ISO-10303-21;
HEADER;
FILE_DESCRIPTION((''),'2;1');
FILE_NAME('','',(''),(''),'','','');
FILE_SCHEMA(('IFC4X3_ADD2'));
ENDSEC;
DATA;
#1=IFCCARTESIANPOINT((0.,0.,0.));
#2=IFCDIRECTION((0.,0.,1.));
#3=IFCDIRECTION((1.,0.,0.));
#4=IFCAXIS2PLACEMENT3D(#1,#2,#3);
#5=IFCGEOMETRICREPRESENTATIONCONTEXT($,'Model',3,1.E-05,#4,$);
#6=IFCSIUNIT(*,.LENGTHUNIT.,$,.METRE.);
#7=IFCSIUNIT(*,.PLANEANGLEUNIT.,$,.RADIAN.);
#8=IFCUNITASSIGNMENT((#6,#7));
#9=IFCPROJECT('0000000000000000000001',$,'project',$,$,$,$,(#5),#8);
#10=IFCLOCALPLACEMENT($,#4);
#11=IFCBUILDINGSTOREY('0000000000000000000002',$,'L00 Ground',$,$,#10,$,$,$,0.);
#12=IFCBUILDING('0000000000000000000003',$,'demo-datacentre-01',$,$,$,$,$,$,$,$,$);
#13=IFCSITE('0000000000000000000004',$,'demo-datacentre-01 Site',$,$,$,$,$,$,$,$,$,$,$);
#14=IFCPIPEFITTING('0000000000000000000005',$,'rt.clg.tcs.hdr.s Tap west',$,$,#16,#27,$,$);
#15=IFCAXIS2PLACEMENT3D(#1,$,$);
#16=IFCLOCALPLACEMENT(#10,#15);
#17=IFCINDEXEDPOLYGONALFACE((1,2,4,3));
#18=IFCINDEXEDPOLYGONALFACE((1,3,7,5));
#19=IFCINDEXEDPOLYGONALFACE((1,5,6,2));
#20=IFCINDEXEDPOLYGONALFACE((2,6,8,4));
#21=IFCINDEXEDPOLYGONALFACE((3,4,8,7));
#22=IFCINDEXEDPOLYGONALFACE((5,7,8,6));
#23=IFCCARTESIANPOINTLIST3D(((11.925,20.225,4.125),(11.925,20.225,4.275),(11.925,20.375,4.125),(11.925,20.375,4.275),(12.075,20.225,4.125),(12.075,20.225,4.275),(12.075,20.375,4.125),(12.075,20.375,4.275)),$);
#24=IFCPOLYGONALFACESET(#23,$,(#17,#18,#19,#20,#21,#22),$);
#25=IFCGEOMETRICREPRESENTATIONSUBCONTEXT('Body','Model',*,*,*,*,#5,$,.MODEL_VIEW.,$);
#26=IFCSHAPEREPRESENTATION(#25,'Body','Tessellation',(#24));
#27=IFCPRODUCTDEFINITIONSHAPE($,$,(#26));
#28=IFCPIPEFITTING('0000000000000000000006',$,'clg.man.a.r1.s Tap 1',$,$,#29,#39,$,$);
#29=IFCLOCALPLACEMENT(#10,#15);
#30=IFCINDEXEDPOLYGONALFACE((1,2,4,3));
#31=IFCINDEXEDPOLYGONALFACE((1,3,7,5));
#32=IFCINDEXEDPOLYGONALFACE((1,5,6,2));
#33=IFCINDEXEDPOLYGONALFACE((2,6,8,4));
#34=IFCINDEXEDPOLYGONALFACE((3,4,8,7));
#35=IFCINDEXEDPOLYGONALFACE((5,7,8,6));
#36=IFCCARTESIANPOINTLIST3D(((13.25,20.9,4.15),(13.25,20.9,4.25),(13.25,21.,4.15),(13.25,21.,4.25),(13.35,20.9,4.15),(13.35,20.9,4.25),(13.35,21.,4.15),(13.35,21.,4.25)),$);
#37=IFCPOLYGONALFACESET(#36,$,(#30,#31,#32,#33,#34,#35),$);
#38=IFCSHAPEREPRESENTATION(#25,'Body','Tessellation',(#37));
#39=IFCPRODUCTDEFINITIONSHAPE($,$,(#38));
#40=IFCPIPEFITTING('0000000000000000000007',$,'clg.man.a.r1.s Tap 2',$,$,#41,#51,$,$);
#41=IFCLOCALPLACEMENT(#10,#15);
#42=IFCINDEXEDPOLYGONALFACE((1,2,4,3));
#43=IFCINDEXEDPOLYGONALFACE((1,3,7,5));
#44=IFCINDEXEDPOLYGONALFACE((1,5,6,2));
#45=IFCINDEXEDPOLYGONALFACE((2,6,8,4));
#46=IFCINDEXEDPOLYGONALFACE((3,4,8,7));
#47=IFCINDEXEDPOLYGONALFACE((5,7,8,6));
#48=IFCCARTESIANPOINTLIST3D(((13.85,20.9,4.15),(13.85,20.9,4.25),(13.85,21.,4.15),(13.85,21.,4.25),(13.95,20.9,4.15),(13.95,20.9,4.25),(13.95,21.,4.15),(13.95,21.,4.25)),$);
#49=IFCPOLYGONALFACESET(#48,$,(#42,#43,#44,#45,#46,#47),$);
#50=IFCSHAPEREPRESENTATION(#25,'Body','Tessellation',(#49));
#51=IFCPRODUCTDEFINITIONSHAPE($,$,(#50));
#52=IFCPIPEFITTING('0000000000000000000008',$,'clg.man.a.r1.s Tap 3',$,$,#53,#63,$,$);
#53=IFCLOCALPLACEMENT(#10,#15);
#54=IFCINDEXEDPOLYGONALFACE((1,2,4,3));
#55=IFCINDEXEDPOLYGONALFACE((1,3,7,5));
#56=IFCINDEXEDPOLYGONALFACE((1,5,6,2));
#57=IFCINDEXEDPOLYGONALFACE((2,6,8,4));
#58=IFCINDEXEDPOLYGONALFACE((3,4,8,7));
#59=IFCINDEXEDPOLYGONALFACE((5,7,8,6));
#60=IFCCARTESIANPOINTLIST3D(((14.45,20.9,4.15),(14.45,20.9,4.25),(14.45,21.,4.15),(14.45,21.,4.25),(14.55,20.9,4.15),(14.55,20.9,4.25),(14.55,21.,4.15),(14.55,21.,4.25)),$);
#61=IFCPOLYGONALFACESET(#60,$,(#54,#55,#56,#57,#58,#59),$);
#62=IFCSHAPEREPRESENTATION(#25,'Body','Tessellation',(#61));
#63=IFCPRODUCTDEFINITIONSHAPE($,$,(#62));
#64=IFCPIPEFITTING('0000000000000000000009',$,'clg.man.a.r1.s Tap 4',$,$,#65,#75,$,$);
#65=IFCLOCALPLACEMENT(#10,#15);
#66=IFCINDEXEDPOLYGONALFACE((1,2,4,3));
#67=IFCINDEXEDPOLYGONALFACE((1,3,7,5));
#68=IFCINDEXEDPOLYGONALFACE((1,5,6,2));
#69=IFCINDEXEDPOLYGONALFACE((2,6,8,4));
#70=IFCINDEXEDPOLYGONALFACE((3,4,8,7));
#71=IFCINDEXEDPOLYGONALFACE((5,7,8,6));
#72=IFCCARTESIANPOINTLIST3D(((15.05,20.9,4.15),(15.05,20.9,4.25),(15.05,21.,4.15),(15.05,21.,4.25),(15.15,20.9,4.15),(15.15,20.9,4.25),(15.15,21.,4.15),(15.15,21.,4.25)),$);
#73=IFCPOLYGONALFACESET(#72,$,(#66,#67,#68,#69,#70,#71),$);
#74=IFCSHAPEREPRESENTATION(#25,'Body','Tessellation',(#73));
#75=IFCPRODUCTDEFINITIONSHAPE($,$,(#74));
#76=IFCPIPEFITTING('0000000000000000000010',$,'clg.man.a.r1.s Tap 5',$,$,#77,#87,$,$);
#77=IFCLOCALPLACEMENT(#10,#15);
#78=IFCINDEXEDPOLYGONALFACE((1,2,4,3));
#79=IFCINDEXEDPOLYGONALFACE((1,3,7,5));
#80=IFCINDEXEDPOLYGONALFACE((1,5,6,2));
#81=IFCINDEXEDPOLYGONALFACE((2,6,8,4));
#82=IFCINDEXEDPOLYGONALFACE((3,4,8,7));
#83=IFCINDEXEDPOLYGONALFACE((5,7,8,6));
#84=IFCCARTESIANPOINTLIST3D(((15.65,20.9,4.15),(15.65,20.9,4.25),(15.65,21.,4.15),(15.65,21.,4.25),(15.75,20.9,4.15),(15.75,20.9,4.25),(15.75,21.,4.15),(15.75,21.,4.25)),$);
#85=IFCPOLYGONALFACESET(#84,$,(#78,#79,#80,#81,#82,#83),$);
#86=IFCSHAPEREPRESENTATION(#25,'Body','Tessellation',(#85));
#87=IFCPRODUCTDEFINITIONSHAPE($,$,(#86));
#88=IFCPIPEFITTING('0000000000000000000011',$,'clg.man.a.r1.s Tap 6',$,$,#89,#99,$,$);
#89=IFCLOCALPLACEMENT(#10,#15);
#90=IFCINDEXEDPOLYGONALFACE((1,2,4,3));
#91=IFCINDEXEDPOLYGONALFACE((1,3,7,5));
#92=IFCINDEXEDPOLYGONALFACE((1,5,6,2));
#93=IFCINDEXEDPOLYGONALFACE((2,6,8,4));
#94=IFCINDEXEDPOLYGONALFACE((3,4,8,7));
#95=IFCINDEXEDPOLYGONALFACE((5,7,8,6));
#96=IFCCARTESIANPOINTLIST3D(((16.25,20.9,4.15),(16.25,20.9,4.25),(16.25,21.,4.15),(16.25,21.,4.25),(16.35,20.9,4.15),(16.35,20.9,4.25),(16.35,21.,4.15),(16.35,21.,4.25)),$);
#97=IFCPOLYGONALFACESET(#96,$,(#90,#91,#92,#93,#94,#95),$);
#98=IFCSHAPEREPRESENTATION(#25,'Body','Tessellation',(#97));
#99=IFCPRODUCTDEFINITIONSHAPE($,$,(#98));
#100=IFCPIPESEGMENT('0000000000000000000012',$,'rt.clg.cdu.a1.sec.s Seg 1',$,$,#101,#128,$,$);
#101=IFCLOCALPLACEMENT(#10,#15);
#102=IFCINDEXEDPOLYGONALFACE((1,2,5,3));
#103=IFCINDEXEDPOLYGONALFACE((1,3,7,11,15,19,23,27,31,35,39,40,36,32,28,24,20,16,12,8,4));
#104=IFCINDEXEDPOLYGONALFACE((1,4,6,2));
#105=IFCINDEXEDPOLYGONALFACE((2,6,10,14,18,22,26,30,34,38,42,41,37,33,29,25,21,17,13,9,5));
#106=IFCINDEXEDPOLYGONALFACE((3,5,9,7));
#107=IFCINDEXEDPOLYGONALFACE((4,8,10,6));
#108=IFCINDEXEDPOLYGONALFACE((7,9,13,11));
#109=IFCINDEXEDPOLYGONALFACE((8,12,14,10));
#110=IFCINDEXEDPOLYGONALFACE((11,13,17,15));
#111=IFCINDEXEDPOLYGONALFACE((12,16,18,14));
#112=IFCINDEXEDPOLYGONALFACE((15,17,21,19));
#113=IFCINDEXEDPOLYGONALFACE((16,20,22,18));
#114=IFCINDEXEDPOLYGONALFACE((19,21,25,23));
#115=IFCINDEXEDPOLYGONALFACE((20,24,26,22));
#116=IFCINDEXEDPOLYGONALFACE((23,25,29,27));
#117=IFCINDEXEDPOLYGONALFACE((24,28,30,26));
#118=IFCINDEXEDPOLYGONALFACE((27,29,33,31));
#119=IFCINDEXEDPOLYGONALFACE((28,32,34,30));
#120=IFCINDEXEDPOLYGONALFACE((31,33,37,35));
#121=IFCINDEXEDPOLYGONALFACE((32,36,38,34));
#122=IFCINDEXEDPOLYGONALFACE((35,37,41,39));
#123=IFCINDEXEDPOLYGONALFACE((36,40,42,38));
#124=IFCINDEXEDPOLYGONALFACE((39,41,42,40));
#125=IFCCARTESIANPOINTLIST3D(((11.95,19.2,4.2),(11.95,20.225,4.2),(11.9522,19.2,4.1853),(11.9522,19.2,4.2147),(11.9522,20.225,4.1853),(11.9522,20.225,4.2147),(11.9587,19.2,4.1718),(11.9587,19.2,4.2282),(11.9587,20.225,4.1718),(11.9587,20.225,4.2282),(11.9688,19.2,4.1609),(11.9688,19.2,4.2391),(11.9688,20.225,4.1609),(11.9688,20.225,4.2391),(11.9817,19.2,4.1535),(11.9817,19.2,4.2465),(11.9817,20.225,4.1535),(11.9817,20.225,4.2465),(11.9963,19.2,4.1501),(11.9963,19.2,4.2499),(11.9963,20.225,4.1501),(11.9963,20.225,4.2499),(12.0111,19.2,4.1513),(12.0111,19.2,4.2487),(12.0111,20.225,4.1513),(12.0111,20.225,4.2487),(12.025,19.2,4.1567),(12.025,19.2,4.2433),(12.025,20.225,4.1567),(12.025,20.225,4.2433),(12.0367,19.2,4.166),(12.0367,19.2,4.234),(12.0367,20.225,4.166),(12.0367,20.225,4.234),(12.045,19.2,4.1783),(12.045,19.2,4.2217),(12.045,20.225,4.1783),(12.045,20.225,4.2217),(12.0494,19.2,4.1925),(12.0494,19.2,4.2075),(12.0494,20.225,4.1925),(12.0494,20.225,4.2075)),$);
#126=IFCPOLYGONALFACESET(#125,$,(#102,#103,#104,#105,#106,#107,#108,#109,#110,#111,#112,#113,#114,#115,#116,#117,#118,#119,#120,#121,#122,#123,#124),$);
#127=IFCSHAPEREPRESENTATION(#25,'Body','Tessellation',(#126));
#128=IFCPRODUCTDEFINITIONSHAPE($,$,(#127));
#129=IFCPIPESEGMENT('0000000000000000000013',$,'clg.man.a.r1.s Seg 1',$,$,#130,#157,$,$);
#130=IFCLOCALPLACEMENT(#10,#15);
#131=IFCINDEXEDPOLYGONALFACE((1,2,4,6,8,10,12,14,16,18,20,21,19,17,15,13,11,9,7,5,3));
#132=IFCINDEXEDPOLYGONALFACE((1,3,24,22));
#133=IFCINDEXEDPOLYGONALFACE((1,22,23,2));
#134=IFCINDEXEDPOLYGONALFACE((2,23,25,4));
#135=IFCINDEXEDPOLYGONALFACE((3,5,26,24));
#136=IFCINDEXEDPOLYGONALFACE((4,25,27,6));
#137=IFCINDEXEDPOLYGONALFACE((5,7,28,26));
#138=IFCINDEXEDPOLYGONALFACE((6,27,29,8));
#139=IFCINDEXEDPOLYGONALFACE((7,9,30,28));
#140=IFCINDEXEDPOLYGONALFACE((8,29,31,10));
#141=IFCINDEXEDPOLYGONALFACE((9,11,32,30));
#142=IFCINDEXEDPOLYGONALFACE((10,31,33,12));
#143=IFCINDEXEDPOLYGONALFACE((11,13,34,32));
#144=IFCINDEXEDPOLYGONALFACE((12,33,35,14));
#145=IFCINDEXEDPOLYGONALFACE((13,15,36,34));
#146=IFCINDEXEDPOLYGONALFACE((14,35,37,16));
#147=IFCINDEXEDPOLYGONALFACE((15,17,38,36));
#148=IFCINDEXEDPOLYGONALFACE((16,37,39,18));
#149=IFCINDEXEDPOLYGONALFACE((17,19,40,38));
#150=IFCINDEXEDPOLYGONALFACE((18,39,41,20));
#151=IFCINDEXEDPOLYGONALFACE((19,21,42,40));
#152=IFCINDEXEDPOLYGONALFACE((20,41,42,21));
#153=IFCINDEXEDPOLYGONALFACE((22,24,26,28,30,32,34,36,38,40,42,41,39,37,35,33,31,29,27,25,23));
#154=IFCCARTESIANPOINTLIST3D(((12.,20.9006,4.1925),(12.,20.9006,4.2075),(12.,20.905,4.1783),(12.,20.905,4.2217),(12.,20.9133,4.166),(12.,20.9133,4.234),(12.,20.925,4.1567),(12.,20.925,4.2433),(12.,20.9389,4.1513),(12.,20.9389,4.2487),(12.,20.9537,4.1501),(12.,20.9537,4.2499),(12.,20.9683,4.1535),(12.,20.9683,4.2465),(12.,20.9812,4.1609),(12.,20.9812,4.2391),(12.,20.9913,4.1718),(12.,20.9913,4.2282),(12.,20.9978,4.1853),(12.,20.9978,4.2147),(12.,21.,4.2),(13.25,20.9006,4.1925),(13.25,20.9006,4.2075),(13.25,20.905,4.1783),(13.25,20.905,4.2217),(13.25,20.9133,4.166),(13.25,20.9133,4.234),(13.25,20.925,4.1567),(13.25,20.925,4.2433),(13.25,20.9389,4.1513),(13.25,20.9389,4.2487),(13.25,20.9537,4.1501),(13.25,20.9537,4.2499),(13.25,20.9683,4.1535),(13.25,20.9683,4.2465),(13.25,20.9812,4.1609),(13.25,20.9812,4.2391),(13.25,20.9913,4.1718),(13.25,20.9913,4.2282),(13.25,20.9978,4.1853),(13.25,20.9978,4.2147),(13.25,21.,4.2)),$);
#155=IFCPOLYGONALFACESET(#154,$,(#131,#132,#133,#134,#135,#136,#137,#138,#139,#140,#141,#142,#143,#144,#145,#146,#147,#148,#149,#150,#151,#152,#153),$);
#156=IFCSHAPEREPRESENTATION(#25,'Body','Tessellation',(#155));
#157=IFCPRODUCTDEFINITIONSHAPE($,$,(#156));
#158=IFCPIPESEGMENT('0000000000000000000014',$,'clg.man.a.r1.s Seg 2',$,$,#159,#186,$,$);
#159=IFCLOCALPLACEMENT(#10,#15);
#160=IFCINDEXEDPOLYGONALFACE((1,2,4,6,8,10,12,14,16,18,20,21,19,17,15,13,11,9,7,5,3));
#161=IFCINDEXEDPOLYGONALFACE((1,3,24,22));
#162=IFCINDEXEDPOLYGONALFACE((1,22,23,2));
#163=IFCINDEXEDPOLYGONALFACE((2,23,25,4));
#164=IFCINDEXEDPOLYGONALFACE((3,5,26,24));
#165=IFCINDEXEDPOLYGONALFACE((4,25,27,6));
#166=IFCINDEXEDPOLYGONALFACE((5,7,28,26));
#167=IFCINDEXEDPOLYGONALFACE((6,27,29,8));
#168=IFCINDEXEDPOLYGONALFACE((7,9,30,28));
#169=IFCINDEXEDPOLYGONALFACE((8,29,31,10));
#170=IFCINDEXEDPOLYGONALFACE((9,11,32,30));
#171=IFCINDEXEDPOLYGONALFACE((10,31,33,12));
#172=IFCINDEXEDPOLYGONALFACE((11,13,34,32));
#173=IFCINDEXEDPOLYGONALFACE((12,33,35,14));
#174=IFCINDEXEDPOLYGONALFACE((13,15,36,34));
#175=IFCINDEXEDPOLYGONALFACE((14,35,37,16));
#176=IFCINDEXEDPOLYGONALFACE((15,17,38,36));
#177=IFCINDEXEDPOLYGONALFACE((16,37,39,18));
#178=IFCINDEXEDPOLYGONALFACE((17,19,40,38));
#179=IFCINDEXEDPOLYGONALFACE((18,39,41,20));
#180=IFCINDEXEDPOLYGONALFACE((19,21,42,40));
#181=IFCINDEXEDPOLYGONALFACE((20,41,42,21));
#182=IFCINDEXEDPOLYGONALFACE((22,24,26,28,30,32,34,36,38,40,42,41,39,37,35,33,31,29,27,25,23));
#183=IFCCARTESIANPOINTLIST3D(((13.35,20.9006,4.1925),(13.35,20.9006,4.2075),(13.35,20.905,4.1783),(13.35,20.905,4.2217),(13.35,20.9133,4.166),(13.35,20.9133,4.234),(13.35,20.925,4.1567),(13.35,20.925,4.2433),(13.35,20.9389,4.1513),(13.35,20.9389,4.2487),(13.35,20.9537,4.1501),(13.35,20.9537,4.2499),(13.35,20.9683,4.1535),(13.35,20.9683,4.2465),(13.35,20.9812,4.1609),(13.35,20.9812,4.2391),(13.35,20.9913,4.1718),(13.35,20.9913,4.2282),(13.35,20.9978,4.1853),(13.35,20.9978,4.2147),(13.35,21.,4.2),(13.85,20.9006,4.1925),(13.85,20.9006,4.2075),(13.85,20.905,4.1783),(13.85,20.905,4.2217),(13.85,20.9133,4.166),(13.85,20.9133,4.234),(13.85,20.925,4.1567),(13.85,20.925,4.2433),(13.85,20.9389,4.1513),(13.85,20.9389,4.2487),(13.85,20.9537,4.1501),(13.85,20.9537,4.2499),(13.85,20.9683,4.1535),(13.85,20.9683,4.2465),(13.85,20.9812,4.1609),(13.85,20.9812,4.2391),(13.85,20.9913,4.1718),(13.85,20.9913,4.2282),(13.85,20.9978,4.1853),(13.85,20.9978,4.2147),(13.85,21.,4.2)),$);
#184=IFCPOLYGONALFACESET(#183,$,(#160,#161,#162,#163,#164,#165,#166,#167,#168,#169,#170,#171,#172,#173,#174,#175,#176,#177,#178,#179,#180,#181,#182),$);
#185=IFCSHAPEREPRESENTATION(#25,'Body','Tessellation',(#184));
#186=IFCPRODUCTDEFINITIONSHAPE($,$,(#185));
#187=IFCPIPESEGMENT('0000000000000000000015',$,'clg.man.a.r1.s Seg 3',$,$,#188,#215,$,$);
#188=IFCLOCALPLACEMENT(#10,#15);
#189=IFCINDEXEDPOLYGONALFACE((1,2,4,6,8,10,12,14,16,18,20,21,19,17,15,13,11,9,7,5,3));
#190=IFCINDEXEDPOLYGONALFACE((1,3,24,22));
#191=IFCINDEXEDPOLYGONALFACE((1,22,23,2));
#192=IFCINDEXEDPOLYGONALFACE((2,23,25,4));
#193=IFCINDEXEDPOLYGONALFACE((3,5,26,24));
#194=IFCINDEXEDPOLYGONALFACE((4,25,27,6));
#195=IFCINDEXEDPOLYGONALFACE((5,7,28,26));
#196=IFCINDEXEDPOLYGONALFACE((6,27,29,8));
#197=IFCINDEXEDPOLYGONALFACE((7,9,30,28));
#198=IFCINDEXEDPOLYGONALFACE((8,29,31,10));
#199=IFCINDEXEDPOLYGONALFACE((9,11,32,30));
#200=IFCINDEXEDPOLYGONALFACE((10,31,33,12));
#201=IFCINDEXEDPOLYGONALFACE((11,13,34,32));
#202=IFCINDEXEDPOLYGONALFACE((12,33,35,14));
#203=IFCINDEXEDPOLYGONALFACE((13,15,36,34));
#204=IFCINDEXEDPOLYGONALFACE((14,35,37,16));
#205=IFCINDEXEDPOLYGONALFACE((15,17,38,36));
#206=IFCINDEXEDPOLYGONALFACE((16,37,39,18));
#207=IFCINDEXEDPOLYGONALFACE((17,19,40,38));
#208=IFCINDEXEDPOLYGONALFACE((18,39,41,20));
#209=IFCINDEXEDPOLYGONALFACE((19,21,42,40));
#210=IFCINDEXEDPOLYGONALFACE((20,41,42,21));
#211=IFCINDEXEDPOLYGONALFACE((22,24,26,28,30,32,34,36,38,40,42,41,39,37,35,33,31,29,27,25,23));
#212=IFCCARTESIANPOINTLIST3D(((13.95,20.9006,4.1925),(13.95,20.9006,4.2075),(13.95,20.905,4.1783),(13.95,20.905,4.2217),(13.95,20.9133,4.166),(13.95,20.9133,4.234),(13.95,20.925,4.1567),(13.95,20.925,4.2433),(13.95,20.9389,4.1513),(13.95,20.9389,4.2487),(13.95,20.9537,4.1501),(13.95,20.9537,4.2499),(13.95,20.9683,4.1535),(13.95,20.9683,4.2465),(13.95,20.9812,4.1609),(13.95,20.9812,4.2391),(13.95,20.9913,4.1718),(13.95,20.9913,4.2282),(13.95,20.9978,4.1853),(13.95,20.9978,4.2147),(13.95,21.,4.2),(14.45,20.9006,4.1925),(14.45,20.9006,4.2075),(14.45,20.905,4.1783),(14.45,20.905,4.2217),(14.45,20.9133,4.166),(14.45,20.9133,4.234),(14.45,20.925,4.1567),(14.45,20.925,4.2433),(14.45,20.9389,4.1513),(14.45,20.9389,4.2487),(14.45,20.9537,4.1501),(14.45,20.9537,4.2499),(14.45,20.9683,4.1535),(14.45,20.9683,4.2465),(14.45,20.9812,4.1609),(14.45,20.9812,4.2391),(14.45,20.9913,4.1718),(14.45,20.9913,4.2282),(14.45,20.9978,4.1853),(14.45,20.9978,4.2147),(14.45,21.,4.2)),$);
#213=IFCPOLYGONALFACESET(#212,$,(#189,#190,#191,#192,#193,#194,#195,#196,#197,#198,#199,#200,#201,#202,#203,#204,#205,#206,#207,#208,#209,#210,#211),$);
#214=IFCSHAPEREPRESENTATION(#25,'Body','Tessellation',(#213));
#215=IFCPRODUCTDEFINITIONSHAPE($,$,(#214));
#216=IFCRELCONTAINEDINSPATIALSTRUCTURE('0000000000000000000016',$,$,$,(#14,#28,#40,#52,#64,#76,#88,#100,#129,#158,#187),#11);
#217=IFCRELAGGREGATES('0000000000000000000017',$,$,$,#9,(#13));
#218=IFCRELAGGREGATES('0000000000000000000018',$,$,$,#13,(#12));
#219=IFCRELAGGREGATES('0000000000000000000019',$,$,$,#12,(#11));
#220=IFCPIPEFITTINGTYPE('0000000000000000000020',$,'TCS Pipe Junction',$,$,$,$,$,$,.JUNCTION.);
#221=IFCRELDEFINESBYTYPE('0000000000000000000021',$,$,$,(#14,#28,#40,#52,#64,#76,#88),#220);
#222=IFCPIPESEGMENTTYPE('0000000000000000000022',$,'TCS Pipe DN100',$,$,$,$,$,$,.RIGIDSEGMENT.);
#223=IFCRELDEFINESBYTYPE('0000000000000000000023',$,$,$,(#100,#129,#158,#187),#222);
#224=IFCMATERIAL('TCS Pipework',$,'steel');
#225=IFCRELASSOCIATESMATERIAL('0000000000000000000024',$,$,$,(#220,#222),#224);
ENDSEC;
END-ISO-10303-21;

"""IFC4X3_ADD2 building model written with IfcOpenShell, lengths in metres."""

from ifc_helpers import new_model, si_unit, frame, origin_with_axes, place, context, subcontext, project, spatial, rectangle, circle, extrude, material, type_object, element, save


model = new_model("IFC4X3_ADD2")

# Units and contexts
model_context = context("Model", 3, precision=1e-05, world=origin_with_axes())
body_context = subcontext(model_context, "Body", "Model", "MODEL_VIEW")
ifc_project = project(units=[si_unit("LENGTHUNIT", "METRE"), si_unit("PLANEANGLEUNIT", "RADIAN")], contexts=[model_context])

# Site, building, storey
site = spatial("IfcSite", under=ifc_project, Name="demo-datacentre-01 Site")
building = spatial("IfcBuilding", under=site, Name="demo-datacentre-01")
storey_placement = place(None, origin_with_axes())
storey = spatial("IfcBuildingStorey", under=building, at=storey_placement, Name="L00 Ground", Elevation=0.0)

# Pipe fittings
ifc_material_1 = material(Name="TCS Pipework", Category="steel")
pipe_fitting_type = type_object("IfcPipeFittingType", Name="TCS Pipe Junction", PredefinedType="JUNCTION", material=ifc_material_1)
pipe_fitting_placement = place(storey_placement, frame((12.0, 20.3, 4.125), z_axis=(0.0, 0.0, 1.0), x_axis=(1.0, 0.0, 0.0)))
element("IfcPipeFitting", 1, at=pipe_fitting_placement, inside=storey, type_object=pipe_fitting_type, Name="rt.clg.tcs.hdr.s Tap west", context=body_context, shape_type="SweptSolid", body=[
    extrude(rectangle(XDim=0.15, YDim=0.15), origin_with_axes(), (0.0, 0.0, 1.0), 0.15),
])
for number, where, z_axis, x_axis, name in (
    (2, (13.3, 20.95, 4.15), (0.0, 0.0, 1.0), (1.0, 0.0, 0.0), "clg.man.a.r1.s Tap 1"),
    (3, (13.9, 20.95, 4.15), (0.0, 0.0, 1.0), (1.0, 0.0, 0.0), "clg.man.a.r1.s Tap 2"),
    (4, (14.5, 20.95, 4.15), (0.0, 0.0, 1.0), (1.0, 0.0, 0.0), "clg.man.a.r1.s Tap 3"),
    (5, (15.1, 20.95, 4.15), (0.0, 0.0, 1.0), (1.0, 0.0, 0.0), "clg.man.a.r1.s Tap 4"),
    (6, (15.7, 20.95, 4.15), (0.0, 0.0, 1.0), (1.0, 0.0, 0.0), "clg.man.a.r1.s Tap 5"),
    (7, (16.3, 20.95, 4.15), (0.0, 0.0, 1.0), (1.0, 0.0, 0.0), "clg.man.a.r1.s Tap 6"),
):
    element("IfcPipeFitting", number, at=place(storey_placement, frame(where, z_axis=z_axis, x_axis=x_axis)), inside=storey, type_object=pipe_fitting_type, Name=name, context=body_context, shape_type="SweptSolid", body=[
        extrude(rectangle(XDim=0.1, YDim=0.1), origin_with_axes(), (0.0, 0.0, 1.0), 0.1),
    ])

# Pipe segments
pipe_segment_type_1 = type_object("IfcPipeSegmentType", Name="TCS Pipe DN100", PredefinedType="RIGIDSEGMENT", material=ifc_material_1)
pipe_segment_1_placement = place(storey_placement, frame((12.0, 19.2, 4.2), z_axis=(0.0, 1.0, 0.0), x_axis=(-1.0, 0.0, 0.0)))
element("IfcPipeSegment", 8, at=pipe_segment_1_placement, inside=storey, type_object=pipe_segment_type_1, Name="rt.clg.cdu.a1.sec.s Seg 1", context=body_context, shape_type="SweptSolid", body=[
    extrude(circle(Radius=0.05), origin_with_axes(), (0.0, 0.0, 1.0), 1.025),
])
pipe_segment_2_placement = place(storey_placement, frame((12.0, 20.95, 4.2), z_axis=(1.0, 0.0, 0.0), x_axis=(0.0, 1.0, 0.0)))
element("IfcPipeSegment", 9, at=pipe_segment_2_placement, inside=storey, type_object=pipe_segment_type_1, Name="clg.man.a.r1.s Seg 1", context=body_context, shape_type="SweptSolid", body=[
    extrude(circle(Radius=0.05), origin_with_axes(), (0.0, 0.0, 1.0), 1.25),
])
for number, where, z_axis, x_axis, name in (
    (10, (13.35, 20.95, 4.2), (1.0, 0.0, 0.0), (0.0, 1.0, 0.0), "clg.man.a.r1.s Seg 2"),
    (11, (13.95, 20.95, 4.2), (1.0, 0.0, 0.0), (0.0, 1.0, 0.0), "clg.man.a.r1.s Seg 3"),
):
    element("IfcPipeSegment", number, at=place(storey_placement, frame(where, z_axis=z_axis, x_axis=x_axis)), inside=storey, type_object=pipe_segment_type_1, Name=name, context=body_context, shape_type="SweptSolid", body=[
        extrude(circle(Radius=0.05), origin_with_axes(), (0.0, 0.0, 1.0), 0.5),
    ])

save(model, "model.ifc")
